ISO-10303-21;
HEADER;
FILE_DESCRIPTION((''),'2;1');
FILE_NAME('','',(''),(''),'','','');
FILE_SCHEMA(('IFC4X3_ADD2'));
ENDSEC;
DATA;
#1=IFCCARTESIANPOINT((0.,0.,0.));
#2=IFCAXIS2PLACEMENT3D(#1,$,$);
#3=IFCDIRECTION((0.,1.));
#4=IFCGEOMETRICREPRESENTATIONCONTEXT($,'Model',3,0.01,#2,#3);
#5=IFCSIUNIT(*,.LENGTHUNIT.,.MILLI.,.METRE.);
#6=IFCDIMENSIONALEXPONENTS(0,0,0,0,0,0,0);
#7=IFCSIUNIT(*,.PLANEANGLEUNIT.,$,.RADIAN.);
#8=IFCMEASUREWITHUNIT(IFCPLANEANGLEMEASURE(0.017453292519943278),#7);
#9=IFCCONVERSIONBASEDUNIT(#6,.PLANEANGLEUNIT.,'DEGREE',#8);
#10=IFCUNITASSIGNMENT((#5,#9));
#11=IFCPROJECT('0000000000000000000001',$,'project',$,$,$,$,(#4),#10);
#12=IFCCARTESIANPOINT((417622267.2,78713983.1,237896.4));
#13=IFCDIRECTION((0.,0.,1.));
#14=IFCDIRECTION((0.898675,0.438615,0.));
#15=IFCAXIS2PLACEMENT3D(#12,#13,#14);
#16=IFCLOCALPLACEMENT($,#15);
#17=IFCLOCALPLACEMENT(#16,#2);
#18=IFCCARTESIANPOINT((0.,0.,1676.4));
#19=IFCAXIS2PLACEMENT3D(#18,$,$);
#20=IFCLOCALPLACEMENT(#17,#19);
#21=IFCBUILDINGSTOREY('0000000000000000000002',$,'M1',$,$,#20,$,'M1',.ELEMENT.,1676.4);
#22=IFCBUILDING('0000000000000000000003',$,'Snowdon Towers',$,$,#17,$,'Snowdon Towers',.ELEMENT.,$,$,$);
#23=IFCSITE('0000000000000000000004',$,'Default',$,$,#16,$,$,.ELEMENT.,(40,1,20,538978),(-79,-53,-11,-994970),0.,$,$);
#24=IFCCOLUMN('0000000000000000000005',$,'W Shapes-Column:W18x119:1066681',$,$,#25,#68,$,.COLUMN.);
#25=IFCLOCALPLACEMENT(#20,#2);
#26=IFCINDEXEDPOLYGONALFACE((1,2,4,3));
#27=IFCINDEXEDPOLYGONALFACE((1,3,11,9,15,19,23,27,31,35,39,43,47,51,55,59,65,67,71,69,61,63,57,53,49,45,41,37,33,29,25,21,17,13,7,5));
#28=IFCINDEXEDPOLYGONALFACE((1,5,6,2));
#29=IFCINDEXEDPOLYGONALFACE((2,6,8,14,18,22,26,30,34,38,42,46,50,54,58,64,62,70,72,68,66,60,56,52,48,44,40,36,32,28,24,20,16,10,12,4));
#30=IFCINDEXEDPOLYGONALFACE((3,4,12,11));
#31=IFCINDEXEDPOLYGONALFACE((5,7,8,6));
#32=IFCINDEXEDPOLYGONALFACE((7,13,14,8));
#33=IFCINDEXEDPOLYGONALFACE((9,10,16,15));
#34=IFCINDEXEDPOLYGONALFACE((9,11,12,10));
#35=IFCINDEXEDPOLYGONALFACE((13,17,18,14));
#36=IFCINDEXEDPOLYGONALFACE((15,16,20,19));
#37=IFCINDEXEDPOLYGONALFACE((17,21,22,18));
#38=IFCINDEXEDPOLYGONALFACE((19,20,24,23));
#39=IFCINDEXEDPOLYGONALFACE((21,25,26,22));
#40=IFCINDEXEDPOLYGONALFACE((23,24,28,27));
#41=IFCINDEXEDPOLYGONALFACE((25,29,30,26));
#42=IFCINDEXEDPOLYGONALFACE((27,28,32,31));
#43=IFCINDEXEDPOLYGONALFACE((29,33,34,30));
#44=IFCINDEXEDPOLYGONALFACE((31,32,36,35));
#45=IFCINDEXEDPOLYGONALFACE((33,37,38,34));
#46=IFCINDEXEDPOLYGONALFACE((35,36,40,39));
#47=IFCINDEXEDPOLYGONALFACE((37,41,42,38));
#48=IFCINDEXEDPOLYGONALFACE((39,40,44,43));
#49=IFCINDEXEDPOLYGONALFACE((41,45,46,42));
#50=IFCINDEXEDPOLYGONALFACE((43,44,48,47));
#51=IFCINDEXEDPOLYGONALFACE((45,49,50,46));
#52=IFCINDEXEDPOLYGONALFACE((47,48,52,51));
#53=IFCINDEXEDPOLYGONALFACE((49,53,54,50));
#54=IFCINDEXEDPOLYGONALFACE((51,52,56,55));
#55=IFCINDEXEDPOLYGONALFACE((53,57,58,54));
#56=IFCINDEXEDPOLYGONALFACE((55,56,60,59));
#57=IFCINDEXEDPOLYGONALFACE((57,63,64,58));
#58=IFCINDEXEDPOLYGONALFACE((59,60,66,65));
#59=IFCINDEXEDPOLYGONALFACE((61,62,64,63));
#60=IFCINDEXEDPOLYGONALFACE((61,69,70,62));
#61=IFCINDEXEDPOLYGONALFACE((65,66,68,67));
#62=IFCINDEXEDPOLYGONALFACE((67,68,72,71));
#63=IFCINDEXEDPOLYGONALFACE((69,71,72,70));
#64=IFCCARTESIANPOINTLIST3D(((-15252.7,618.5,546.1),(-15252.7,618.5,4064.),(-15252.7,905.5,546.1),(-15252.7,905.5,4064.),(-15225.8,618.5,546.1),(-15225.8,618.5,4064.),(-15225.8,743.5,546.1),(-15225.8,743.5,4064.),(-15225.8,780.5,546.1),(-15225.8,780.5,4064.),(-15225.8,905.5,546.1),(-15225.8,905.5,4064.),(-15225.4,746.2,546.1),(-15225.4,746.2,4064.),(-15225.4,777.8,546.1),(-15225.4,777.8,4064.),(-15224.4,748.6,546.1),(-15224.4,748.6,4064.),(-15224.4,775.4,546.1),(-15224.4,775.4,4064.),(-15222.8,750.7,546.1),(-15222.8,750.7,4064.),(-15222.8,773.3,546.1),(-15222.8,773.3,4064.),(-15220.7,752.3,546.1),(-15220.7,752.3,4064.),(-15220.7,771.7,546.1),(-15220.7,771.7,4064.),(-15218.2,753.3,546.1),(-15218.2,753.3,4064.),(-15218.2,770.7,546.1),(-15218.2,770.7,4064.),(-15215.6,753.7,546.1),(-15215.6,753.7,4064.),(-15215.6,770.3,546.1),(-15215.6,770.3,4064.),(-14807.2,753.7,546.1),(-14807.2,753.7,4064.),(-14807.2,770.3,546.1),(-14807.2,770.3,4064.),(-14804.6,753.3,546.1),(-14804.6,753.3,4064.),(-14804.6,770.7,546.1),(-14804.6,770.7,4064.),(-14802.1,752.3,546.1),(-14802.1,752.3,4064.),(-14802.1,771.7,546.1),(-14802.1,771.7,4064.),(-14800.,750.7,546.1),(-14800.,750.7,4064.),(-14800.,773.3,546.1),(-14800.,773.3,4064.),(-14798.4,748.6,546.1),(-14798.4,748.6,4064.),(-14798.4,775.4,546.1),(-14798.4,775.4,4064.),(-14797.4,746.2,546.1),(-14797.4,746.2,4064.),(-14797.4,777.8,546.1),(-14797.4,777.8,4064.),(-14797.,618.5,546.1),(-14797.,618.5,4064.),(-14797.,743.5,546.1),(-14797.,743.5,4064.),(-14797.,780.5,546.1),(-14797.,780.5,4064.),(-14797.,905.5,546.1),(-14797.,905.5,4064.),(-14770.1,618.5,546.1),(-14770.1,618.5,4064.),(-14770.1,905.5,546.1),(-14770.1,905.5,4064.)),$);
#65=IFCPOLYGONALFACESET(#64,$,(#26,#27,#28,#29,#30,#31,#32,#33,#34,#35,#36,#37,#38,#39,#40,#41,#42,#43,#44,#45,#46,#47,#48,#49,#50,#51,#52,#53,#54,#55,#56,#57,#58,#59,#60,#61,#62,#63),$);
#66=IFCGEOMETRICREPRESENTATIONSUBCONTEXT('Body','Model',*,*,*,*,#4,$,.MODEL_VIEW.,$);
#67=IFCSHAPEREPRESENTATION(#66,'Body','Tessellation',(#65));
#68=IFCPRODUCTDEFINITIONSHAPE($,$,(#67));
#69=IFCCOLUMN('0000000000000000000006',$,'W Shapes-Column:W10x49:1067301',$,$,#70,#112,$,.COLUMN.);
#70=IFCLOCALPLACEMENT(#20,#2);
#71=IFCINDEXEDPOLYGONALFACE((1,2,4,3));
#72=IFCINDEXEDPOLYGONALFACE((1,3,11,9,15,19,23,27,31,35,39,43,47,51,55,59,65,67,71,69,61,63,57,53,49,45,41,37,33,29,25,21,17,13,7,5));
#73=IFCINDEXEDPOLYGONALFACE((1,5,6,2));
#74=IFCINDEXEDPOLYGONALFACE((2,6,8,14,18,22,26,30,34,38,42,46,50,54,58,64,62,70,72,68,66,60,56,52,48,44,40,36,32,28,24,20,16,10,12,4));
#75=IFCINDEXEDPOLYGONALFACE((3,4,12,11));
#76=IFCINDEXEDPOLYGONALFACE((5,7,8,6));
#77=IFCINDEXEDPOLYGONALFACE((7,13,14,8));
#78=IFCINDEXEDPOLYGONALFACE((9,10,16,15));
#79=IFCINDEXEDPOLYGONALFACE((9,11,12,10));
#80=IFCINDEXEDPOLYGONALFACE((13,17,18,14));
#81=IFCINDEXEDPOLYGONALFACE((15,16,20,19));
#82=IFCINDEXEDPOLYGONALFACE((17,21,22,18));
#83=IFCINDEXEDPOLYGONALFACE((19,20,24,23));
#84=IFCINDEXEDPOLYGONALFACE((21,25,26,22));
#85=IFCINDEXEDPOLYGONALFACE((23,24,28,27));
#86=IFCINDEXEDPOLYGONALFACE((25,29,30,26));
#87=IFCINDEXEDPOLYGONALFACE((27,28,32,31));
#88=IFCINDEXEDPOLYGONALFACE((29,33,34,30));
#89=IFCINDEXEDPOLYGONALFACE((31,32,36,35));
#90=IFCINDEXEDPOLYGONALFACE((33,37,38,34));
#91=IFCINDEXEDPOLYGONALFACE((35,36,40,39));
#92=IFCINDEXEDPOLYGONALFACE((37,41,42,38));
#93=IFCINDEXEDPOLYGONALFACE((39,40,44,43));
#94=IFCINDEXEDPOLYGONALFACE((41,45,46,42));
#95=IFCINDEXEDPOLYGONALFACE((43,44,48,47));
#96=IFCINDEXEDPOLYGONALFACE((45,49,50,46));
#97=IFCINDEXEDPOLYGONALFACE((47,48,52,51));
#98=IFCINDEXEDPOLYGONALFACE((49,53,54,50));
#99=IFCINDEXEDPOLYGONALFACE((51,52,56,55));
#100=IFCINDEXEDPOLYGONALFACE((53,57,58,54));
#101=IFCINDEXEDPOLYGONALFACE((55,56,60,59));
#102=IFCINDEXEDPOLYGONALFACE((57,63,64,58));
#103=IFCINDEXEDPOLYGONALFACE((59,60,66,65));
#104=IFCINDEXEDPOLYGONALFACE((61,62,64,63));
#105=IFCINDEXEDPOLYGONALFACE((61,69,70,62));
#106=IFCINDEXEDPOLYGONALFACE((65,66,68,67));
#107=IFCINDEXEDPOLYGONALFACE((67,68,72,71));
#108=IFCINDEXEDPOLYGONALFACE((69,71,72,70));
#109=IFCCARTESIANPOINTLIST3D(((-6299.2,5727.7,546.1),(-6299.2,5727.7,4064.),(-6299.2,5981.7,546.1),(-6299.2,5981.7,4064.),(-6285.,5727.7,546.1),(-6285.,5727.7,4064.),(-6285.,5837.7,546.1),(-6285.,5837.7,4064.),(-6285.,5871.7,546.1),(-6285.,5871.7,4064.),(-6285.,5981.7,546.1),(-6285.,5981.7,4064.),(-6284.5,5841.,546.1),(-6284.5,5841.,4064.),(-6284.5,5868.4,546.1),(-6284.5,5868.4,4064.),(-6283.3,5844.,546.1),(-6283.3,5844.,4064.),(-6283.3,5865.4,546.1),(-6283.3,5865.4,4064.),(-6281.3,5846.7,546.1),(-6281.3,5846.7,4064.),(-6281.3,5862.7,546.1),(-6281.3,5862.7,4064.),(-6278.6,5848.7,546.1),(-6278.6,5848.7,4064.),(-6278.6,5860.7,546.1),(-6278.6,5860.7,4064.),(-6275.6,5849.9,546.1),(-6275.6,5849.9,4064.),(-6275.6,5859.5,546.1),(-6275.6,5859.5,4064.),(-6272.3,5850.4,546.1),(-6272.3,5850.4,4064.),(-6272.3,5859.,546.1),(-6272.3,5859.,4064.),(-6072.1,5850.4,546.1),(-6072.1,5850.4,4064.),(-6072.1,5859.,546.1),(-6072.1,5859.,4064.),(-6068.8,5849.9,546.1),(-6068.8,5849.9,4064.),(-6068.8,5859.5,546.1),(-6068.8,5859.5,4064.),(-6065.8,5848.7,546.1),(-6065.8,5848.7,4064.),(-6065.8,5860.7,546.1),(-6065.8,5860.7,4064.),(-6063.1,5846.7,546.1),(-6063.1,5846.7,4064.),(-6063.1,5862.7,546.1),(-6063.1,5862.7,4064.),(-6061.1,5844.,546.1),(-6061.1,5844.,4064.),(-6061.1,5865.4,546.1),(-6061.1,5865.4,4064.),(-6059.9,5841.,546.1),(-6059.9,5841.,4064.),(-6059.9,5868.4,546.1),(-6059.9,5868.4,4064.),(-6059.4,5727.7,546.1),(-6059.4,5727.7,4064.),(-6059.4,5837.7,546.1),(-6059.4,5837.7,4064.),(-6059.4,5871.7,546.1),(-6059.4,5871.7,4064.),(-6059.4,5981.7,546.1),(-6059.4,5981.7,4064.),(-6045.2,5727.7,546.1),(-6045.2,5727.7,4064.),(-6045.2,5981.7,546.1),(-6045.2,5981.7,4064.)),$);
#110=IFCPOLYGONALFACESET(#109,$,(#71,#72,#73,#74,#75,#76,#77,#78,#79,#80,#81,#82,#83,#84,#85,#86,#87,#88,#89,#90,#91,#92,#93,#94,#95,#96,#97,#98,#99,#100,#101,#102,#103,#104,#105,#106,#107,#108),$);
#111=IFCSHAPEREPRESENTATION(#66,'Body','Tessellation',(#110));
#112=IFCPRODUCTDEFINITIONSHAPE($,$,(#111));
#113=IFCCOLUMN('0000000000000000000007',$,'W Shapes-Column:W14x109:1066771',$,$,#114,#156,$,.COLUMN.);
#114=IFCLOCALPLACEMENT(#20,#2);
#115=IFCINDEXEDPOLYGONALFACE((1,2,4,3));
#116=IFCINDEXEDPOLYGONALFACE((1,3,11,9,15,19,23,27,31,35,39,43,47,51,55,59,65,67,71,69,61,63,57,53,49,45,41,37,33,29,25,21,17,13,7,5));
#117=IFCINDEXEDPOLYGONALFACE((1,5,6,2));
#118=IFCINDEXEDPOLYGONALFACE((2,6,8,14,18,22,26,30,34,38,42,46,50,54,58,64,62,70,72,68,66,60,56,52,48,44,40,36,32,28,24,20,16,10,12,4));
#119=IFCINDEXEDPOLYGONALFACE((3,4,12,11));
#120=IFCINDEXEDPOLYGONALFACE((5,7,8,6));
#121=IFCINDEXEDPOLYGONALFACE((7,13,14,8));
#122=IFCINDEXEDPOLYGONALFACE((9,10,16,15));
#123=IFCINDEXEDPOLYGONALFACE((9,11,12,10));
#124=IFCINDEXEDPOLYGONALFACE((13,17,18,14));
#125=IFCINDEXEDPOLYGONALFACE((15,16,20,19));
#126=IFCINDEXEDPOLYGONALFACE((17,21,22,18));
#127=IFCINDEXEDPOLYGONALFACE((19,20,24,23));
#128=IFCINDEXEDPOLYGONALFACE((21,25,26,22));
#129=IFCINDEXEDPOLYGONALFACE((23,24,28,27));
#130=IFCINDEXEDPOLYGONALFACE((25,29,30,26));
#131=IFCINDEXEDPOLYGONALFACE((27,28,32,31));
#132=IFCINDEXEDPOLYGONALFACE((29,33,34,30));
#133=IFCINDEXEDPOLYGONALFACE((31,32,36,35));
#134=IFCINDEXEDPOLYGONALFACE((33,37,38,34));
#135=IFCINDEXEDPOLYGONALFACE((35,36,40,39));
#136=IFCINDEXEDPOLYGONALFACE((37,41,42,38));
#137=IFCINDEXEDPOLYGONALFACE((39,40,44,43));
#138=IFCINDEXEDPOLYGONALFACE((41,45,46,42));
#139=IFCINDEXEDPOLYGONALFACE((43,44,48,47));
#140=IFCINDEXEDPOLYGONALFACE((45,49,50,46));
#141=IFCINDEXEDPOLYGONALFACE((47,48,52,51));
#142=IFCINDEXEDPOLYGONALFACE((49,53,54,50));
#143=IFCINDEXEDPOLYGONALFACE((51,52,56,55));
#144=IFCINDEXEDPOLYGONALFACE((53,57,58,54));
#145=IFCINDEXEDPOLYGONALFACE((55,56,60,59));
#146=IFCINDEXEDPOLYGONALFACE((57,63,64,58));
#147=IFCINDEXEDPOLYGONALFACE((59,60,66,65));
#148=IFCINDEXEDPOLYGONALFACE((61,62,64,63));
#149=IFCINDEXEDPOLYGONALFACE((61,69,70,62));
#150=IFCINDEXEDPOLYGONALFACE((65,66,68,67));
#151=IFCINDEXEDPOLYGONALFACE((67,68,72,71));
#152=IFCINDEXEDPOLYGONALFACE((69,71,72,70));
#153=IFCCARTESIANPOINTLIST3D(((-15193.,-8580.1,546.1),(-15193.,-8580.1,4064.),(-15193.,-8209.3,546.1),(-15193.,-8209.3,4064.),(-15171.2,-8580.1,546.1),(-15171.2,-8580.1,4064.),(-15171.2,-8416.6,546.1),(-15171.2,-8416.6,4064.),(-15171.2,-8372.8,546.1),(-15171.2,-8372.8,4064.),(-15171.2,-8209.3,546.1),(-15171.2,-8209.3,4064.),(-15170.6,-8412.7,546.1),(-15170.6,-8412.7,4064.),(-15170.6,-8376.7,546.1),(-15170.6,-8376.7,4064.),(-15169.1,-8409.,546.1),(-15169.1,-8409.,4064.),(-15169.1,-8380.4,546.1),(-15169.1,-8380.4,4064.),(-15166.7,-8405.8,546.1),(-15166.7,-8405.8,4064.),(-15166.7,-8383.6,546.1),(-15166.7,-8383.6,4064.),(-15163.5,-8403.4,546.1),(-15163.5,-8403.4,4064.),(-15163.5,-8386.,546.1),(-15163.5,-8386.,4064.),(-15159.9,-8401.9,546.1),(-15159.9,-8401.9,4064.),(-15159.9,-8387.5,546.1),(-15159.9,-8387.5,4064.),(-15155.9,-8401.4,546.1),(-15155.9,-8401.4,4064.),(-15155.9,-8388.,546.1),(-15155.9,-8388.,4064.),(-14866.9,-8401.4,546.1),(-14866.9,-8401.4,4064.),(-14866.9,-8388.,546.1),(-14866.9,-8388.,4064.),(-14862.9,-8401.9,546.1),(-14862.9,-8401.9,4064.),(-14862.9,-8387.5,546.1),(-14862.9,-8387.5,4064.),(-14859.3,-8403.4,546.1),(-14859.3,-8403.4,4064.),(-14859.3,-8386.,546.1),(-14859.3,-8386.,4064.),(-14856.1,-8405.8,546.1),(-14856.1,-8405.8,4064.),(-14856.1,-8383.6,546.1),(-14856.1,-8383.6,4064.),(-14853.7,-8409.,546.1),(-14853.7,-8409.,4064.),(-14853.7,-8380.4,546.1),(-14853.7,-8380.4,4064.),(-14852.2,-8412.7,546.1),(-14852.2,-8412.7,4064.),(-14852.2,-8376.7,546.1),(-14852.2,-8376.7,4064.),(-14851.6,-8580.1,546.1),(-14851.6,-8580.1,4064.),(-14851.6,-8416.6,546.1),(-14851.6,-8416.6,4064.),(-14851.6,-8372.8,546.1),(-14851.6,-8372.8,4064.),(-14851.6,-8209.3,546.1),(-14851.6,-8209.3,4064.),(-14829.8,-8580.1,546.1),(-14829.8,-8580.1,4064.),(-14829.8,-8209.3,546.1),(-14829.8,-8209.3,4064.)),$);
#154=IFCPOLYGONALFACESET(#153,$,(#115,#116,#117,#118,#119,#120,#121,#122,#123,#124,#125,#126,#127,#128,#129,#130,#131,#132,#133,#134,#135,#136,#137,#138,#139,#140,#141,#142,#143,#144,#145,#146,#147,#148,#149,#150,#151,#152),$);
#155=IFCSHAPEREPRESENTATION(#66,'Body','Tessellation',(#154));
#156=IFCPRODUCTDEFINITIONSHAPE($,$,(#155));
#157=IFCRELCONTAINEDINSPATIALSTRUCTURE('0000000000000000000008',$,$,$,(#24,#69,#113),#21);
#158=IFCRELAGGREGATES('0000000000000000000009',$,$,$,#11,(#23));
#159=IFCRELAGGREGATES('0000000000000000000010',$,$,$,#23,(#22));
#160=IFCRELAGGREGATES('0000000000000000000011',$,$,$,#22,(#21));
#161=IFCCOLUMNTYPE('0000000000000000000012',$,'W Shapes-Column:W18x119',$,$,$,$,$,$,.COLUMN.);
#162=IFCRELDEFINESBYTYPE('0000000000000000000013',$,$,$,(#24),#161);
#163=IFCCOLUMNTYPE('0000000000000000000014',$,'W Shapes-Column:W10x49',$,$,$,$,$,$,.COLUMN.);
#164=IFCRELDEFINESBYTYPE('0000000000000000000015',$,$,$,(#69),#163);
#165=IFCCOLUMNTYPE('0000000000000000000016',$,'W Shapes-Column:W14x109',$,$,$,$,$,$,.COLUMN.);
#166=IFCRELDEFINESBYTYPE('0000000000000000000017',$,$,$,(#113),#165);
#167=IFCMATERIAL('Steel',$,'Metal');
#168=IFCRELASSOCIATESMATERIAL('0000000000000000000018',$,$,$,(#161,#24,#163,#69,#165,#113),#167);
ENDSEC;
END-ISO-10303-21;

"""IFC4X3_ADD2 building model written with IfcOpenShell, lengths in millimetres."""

from ifc_helpers import new_model, entity, si_unit, converted_unit, direction, frame, frame_2d, origin, place, context, subcontext, project, spatial, i_section, extrude, source, transform, mapped, material, material_profile, profile_set, profile_usage, type_object, type_shapes, element, save


model = new_model("IFC4X3_ADD2")

# Units and contexts
model_context = context("Model", 3, precision=0.01, world=origin(), true_north=direction((0.0, 1.0)))
body_context = subcontext(model_context, "Body", "Model", "MODEL_VIEW")
ifc_project = project(units=[si_unit("LENGTHUNIT", "METRE", prefix="MILLI"), converted_unit("PLANEANGLEUNIT", "DEGREE", entity("IfcPlaneAngleMeasure", 0.017453292519943278), si_unit("PLANEANGLEUNIT", "RADIAN"), dimensions=[0, 0, 0, 0, 0, 0, 0])], contexts=[model_context])

# Site, building, storey
site_placement = place(None, frame((417622267.2, 78713983.1, 237896.4), z_axis=(0.0, 0.0, 1.0), x_axis=(0.898675, 0.438615, 0.0)))
site = spatial("IfcSite", under=ifc_project, at=site_placement, Name="Default", CompositionType="ELEMENT", RefLatitude=(40, 1, 20, 538978), RefLongitude=(-79, -53, -11, -994970), RefElevation=0.0)
building_placement = place(site_placement, origin())
building = spatial("IfcBuilding", under=site, at=building_placement, Name="Snowdon Towers", LongName="Snowdon Towers", CompositionType="ELEMENT")
storey_placement = place(building_placement, frame((0.0, 0.0, 1676.4)))
storey = spatial("IfcBuildingStorey", under=building, at=storey_placement, Name="M1", LongName="M1", CompositionType="ELEMENT", Elevation=1676.4)

# Columns
ifc_material_1 = material(Name="Steel", Category="Metal")
ifc_material_profile_1 = material_profile(ifc_material_1, i_section(OverallWidth=287.0, OverallDepth=482.6, WebThickness=16.6, FlangeThickness=26.9, FilletRadius=10.2, at=frame_2d((0.0, 0.0), x_axis=(1.0, 0.0))), Name="W18x119")
ifc_profile_set_1 = profile_set([ifc_material_profile_1], Name="W18x119")
ifc_profile_usage_1 = profile_usage(ifc_profile_set_1)
column_type_1 = type_object("IfcColumnType", Name="W Shapes-Column:W18x119", PredefinedType="COLUMN", material=ifc_profile_set_1)
shared_shape_1 = source(origin(), body_context, "Body", "SweptSolid", [
    extrude(i_section(OverallWidth=287.0, OverallDepth=482.6, WebThickness=16.6, FlangeThickness=26.9, FilletRadius=10.2, at=frame_2d((0.0, 0.0), x_axis=(1.0, 0.0))), frame((0.0, 0.0, 2222.5), z_axis=(0.0, 0.0, 1.0), x_axis=(-1.0, 0.0, 0.0)), (0.0, 0.0, 1.0), 3517.9),
])
type_shapes(column_type_1, [shared_shape_1])
column_1_placement = place(storey_placement, frame((-15011.4, 762.0, -1676.4), z_axis=(0.0, 0.0, 1.0), x_axis=(0.0, -1.0, 0.0)))
element("IfcColumn", 1, at=column_1_placement, inside=storey, type_object=column_type_1, material=ifc_profile_usage_1, Name="W Shapes-Column:W18x119:1066681", PredefinedType="COLUMN", context=body_context, shape_type="MappedRepresentation", body=[
    mapped(shared_shape_1, transform((0.0, 0.0, 0.0), scale=1.0)),
])
ifc_material_profile_2 = material_profile(ifc_material_1, i_section(OverallWidth=254.0, OverallDepth=254.0, WebThickness=8.6, FlangeThickness=14.2, FilletRadius=12.7, at=frame_2d((0.0, 0.0), x_axis=(1.0, 0.0))), Name="W10x49")
ifc_profile_set_2 = profile_set([ifc_material_profile_2], Name="W10x49")
ifc_profile_usage_2 = profile_usage(ifc_profile_set_2)
column_type_2 = type_object("IfcColumnType", Name="W Shapes-Column:W10x49", PredefinedType="COLUMN", material=ifc_profile_set_2)
shared_shape_2 = source(origin(), body_context, "Body", "SweptSolid", [
    extrude(i_section(OverallWidth=254.0, OverallDepth=254.0, WebThickness=8.6, FlangeThickness=14.2, FilletRadius=12.7, at=frame_2d((0.0, 0.0), x_axis=(1.0, 0.0))), frame((0.0, 0.0, 2222.5), z_axis=(0.0, 0.0, 1.0), x_axis=(-1.0, 0.0, 0.0)), (0.0, 0.0, 1.0), 3517.9),
])
type_shapes(column_type_2, [shared_shape_2])
column_2_placement = place(storey_placement, frame((-6172.2, 5854.7, -1676.4), z_axis=(0.0, 0.0, 1.0), x_axis=(0.0, 1.0, 0.0)))
element("IfcColumn", 2, at=column_2_placement, inside=storey, type_object=column_type_2, material=ifc_profile_usage_2, Name="W Shapes-Column:W10x49:1067301", PredefinedType="COLUMN", context=body_context, shape_type="MappedRepresentation", body=[
    mapped(shared_shape_2, transform((0.0, 0.0, 0.0), scale=1.0)),
])
ifc_material_profile_3 = material_profile(ifc_material_1, i_section(OverallWidth=370.8, OverallDepth=363.2, WebThickness=13.3, FlangeThickness=21.8, FilletRadius=15.2, at=frame_2d((0.0, 0.0), x_axis=(1.0, 0.0))), Name="W14x109")
ifc_profile_set_3 = profile_set([ifc_material_profile_3], Name="W14x109")
ifc_profile_usage_3 = profile_usage(ifc_profile_set_3)
column_type_3 = type_object("IfcColumnType", Name="W Shapes-Column:W14x109", PredefinedType="COLUMN", material=ifc_profile_set_3)
shared_shape_3 = source(origin(), body_context, "Body", "SweptSolid", [
    extrude(i_section(OverallWidth=370.8, OverallDepth=363.2, WebThickness=13.3, FlangeThickness=21.8, FilletRadius=15.2, at=frame_2d((0.0, 0.0), x_axis=(1.0, 0.0))), frame((0.0, 0.0, 2222.5), z_axis=(0.0, 0.0, 1.0), x_axis=(-1.0, 0.0, 0.0)), (0.0, 0.0, 1.0), 3517.9),
])
type_shapes(column_type_3, [shared_shape_3])
for number, where, z_axis, x_axis, name in (
    (3, (-15011.4, -8394.7, -1676.4), (0.0, 0.0, 1.0), (0.0, 1.0, 0.0), "W Shapes-Column:W14x109:1066771"),
):
    element("IfcColumn", number, at=place(storey_placement, frame(where, z_axis=z_axis, x_axis=x_axis)), inside=storey, type_object=column_type_3, material=ifc_profile_usage_3, Name=name, PredefinedType="COLUMN", context=body_context, shape_type="MappedRepresentation", body=[
        mapped(shared_shape_3, transform((0.0, 0.0, 0.0), scale=1.0)),
    ])

save(model, "model.ifc")
